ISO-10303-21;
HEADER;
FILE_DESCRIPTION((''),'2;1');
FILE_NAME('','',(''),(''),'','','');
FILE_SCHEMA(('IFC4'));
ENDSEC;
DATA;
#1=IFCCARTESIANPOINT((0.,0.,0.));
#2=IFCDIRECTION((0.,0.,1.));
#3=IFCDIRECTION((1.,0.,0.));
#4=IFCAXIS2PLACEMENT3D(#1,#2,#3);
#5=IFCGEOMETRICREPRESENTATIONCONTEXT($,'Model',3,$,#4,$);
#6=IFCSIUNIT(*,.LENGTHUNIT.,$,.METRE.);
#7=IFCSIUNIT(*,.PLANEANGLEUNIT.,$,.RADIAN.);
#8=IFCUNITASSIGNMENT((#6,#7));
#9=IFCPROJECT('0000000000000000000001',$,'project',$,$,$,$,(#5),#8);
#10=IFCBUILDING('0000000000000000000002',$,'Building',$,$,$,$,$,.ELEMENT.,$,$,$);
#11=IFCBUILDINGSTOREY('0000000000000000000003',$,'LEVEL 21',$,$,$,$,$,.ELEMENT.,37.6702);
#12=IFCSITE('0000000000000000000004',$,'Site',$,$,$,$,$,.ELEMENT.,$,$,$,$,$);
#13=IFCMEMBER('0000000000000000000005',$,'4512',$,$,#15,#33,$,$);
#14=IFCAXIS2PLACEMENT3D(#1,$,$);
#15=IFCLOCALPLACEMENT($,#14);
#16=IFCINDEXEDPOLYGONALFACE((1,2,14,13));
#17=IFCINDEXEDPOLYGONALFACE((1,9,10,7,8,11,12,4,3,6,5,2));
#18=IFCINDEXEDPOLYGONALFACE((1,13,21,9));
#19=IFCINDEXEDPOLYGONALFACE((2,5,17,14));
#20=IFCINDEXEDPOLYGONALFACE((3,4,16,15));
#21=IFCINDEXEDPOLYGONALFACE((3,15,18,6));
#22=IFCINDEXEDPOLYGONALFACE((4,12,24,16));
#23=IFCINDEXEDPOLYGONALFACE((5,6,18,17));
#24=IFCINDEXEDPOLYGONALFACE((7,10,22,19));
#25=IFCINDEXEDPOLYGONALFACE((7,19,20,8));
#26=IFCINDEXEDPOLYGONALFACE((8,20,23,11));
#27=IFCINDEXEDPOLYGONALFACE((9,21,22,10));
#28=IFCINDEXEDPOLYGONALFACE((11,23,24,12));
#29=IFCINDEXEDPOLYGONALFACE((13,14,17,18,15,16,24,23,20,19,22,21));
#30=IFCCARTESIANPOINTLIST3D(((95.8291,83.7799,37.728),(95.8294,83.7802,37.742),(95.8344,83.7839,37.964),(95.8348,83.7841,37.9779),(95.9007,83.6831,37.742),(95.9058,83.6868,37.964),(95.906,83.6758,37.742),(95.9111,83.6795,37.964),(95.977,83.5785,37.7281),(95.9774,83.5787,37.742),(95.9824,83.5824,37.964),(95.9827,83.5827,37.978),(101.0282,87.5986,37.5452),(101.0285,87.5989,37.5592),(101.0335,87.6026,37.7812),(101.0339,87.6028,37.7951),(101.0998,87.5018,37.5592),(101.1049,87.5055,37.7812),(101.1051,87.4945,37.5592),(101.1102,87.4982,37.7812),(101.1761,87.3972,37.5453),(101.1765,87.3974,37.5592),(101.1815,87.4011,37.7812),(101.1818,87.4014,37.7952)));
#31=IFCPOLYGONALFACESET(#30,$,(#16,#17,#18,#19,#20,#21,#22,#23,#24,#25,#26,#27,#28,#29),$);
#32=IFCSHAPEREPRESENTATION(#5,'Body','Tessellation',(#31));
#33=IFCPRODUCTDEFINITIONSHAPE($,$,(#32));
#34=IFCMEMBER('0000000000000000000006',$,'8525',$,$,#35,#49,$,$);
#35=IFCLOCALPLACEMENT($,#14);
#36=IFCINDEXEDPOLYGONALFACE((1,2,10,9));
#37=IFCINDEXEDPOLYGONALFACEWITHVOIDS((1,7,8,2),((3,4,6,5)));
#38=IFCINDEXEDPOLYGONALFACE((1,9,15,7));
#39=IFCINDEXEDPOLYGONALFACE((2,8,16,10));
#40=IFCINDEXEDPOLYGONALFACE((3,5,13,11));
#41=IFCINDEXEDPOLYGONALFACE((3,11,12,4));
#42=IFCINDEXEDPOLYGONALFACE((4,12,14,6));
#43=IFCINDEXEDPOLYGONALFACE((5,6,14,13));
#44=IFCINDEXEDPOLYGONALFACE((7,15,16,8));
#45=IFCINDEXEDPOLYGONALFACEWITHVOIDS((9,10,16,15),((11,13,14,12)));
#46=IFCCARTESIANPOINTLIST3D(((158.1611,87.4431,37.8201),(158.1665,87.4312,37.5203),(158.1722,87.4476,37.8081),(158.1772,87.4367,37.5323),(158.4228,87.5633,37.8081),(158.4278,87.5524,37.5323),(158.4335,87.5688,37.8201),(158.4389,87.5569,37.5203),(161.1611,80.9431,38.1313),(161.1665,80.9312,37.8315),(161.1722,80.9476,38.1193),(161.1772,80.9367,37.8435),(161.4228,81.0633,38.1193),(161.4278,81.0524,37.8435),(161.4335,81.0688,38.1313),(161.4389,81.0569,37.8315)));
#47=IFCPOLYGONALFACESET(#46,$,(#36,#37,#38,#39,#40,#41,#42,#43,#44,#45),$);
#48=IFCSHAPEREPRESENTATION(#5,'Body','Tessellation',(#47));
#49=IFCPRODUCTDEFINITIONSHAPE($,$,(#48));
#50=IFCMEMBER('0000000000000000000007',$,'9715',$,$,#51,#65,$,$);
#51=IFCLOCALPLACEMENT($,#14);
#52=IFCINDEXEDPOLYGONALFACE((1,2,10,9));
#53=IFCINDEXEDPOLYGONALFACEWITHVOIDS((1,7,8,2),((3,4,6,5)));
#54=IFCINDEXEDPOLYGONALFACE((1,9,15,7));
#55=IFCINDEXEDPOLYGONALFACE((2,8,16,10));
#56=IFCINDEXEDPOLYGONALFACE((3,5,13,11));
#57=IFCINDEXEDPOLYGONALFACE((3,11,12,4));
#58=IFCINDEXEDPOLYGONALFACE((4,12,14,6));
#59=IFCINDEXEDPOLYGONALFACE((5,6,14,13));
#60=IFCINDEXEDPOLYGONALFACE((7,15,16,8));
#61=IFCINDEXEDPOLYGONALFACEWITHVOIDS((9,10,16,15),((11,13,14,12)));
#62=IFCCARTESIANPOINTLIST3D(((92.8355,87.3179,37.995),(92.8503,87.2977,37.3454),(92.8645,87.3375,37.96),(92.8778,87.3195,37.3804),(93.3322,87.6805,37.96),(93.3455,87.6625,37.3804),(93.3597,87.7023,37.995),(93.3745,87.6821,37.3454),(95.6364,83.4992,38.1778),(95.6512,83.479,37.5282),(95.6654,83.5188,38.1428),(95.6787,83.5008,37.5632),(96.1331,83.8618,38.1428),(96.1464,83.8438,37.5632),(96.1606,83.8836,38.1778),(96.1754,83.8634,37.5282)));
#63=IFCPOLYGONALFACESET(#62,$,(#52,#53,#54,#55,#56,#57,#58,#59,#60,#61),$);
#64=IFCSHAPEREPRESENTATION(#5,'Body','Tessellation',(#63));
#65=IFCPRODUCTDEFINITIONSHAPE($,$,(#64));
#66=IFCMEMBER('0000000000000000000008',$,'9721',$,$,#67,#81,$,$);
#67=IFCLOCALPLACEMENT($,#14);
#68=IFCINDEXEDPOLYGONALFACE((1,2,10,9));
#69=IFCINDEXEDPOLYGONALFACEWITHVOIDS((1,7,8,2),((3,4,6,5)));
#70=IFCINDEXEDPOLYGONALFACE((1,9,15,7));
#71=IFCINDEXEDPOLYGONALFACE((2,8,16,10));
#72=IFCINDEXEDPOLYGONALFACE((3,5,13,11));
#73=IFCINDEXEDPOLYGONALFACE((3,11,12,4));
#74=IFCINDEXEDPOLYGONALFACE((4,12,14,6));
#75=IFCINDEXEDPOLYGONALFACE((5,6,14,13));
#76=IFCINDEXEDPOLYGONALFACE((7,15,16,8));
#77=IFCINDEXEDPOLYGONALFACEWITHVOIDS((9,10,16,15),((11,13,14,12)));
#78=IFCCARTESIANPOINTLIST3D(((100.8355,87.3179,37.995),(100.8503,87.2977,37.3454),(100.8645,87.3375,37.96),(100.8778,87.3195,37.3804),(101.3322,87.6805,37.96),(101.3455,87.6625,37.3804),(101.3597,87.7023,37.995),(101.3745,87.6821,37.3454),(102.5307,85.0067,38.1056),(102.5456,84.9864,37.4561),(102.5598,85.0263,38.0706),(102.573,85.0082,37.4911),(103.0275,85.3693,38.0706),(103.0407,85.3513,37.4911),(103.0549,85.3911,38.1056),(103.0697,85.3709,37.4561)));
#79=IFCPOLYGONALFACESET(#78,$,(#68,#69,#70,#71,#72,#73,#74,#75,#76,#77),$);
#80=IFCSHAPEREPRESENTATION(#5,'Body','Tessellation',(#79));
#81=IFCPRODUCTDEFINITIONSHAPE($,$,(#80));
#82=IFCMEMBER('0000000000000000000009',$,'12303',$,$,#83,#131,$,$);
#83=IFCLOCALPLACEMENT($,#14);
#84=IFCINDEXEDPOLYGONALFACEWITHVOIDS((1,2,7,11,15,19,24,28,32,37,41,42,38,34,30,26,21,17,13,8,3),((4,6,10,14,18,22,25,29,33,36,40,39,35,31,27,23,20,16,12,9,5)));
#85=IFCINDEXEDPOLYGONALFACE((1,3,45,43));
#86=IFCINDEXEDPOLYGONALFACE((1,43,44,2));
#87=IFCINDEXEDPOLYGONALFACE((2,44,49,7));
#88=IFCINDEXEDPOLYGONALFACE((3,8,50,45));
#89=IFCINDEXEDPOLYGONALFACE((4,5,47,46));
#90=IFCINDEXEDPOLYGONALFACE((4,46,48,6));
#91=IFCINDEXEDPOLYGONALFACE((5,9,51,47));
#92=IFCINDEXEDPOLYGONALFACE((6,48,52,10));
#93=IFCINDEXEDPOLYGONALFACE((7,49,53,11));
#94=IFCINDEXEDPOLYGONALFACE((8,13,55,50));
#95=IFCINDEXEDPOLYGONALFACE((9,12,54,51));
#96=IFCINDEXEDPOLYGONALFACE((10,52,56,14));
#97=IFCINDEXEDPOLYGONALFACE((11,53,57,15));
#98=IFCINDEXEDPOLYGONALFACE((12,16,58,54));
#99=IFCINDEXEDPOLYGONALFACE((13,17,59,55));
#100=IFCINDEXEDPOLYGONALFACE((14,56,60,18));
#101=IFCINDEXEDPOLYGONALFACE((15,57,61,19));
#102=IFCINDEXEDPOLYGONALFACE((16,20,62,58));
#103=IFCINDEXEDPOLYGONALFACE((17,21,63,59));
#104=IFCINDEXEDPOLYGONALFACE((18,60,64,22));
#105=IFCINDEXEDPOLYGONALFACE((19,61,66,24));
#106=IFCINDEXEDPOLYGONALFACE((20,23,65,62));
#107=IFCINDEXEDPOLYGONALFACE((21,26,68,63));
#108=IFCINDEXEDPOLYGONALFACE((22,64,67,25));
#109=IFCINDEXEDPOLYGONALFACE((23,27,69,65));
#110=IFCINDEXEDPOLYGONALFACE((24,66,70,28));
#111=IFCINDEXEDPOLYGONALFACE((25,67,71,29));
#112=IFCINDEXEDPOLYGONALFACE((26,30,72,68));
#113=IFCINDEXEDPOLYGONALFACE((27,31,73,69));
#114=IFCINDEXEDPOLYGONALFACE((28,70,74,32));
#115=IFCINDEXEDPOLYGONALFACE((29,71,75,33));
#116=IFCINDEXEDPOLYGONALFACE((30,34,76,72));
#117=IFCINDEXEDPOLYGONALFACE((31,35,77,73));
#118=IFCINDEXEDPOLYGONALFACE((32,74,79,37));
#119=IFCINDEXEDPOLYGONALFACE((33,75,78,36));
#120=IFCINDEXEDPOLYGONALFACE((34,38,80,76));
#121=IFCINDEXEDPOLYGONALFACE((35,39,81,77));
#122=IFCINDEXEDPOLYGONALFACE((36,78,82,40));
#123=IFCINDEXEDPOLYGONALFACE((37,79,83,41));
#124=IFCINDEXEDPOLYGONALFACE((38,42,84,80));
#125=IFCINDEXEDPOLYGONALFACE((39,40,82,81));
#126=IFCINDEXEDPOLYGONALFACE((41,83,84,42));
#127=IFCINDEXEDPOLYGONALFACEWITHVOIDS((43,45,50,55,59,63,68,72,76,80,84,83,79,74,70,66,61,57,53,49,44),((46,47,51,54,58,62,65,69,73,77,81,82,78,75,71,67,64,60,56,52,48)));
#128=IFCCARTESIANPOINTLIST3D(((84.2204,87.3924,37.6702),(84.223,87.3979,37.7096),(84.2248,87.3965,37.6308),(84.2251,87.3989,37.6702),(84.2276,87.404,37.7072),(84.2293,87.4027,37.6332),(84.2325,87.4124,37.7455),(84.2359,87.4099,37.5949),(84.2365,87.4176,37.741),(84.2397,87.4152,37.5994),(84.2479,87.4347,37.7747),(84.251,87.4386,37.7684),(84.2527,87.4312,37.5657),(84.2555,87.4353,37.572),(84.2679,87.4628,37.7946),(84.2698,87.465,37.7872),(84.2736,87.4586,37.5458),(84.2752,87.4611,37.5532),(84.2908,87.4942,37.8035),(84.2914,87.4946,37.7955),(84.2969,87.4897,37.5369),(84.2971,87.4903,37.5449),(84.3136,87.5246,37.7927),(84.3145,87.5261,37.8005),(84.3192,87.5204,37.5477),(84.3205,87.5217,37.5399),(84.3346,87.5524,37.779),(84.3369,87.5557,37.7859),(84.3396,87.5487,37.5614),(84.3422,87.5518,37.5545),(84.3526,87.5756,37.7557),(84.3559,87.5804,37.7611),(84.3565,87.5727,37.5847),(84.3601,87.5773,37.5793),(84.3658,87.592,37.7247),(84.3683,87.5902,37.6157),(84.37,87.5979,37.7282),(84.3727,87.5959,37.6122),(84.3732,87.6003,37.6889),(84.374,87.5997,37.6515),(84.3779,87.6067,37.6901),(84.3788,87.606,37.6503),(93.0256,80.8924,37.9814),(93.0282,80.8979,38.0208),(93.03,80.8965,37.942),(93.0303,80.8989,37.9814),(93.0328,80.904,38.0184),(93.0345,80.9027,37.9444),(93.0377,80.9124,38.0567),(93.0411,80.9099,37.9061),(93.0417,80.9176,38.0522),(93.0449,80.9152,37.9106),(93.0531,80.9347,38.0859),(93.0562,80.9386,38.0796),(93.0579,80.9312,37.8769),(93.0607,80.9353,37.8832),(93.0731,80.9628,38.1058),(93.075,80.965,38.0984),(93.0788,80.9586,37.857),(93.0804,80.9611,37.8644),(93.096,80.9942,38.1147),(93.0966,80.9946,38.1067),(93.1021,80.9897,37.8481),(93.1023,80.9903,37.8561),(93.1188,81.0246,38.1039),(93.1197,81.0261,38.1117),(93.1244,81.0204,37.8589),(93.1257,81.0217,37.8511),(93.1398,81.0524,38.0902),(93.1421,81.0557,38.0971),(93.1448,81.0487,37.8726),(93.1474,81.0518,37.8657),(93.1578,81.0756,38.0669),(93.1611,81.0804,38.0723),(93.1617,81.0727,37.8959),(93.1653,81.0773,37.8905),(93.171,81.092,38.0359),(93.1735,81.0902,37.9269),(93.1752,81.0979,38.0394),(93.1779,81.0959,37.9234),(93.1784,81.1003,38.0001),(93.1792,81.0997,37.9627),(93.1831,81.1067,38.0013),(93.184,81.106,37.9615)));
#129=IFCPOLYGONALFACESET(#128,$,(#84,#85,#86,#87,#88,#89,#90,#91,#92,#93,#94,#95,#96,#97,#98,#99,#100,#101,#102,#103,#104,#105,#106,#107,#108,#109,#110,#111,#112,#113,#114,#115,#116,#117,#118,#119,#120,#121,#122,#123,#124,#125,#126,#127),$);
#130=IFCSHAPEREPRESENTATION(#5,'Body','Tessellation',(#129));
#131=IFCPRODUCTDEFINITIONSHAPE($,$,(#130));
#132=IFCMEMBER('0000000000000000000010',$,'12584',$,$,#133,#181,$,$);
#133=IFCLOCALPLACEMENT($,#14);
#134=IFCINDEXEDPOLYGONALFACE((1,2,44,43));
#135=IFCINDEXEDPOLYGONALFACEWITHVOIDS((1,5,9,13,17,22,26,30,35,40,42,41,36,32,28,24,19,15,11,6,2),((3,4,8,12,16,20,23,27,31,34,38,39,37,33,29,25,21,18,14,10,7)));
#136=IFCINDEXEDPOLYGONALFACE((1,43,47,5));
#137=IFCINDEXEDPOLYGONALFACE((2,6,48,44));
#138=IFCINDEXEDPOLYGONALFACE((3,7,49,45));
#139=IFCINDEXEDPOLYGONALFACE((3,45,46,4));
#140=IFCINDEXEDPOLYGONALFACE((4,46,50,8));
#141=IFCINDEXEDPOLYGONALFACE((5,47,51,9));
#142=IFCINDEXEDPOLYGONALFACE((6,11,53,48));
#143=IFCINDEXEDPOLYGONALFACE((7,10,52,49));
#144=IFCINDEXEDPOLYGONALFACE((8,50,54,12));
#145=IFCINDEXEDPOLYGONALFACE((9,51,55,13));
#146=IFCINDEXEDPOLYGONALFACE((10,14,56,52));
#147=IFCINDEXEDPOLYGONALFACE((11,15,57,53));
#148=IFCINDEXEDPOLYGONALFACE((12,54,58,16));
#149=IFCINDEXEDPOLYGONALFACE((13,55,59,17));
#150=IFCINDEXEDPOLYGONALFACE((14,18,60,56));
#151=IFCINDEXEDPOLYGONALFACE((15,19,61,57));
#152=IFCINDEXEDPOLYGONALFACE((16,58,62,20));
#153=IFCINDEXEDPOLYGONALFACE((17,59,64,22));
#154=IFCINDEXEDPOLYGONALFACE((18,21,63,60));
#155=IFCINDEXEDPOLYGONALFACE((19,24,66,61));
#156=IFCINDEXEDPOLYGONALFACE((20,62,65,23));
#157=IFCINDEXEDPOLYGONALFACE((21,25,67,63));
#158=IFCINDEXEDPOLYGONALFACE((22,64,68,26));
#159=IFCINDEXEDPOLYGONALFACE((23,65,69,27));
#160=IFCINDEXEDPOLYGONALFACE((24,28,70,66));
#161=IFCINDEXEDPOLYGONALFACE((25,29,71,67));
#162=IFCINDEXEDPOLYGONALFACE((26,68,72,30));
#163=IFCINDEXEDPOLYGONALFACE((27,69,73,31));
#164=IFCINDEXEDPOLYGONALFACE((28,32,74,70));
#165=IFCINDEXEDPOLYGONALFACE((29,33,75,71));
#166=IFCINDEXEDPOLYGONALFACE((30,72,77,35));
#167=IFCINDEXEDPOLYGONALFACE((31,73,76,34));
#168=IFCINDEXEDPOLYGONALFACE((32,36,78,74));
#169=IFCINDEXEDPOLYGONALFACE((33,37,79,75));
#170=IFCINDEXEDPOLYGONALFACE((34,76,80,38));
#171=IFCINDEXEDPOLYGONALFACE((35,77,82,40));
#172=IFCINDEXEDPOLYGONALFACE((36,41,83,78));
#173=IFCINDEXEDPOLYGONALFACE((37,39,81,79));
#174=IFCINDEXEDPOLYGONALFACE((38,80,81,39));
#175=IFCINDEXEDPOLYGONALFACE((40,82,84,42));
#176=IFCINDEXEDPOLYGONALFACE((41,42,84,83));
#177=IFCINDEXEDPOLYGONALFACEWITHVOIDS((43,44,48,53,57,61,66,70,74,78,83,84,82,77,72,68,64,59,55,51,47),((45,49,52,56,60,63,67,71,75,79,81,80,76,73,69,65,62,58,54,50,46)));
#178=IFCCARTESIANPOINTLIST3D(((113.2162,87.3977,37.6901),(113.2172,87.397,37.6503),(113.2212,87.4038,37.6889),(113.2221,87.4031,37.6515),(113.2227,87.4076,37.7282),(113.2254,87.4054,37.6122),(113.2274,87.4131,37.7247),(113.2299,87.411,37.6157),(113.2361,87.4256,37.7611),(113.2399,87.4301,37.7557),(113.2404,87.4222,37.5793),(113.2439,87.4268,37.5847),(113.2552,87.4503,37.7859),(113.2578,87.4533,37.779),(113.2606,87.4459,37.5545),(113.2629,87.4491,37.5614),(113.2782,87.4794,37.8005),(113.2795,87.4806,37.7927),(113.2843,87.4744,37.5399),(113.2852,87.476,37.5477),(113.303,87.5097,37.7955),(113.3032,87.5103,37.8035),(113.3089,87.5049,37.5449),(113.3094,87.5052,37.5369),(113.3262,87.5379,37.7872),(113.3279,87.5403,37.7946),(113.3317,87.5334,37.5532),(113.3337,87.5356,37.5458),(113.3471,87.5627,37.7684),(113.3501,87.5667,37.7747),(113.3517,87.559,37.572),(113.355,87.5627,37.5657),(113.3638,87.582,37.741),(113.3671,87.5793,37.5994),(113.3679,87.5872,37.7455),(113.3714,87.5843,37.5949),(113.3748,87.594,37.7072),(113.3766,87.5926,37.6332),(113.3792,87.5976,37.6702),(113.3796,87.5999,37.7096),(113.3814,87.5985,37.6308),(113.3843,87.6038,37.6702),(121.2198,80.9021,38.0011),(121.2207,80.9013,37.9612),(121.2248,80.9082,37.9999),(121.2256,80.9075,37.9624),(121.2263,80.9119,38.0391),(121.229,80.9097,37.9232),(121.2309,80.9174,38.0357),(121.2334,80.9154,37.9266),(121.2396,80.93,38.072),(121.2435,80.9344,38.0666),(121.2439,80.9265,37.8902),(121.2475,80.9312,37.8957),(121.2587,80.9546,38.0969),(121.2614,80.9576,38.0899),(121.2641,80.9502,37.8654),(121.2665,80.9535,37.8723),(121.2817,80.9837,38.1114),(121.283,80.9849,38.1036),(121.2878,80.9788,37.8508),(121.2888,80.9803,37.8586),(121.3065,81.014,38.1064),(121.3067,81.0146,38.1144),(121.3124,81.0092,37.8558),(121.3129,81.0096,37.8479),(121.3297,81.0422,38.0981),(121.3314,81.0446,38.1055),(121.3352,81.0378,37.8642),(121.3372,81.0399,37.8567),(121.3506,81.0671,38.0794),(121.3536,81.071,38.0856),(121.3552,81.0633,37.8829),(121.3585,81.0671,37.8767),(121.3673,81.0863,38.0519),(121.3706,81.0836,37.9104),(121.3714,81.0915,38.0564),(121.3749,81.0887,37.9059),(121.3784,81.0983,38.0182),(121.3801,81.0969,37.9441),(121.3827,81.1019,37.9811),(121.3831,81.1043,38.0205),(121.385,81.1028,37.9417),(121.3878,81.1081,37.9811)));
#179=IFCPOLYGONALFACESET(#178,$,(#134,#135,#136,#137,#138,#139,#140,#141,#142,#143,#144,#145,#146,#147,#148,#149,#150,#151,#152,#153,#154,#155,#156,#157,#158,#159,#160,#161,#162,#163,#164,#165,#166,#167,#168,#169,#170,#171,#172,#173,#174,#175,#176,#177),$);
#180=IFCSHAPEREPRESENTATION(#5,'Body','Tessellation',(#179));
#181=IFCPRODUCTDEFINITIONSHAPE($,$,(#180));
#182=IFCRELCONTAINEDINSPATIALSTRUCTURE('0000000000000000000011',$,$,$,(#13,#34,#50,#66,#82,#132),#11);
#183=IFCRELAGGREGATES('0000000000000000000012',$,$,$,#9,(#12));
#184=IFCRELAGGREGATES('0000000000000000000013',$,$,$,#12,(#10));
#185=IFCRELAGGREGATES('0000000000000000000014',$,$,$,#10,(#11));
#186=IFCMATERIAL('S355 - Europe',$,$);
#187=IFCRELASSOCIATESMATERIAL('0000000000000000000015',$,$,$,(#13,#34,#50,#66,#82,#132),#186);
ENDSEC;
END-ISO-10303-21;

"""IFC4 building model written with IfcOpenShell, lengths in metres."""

from ifc_helpers import new_model, si_unit, frame, origin_with_axes, origin_2d_with_axis, place, context, project, spatial, hollow_rectangle, hollow_circle, i_section, extrude, material, material_profile, profile_set, profile_usage, element, save


model = new_model("IFC4")

# Units and contexts
model_context = context("Model", 3, world=origin_with_axes())
ifc_project = project(units=[si_unit("LENGTHUNIT", "METRE"), si_unit("PLANEANGLEUNIT", "RADIAN")], contexts=[model_context])

# Site, building, storey
site = spatial("IfcSite", under=ifc_project, Name="Site", CompositionType="ELEMENT")
building = spatial("IfcBuilding", under=site, Name="Building", CompositionType="ELEMENT")
storey = spatial("IfcBuildingStorey", under=building, Name="LEVEL 21", CompositionType="ELEMENT", Elevation=37.6702)

# Shared definitions
ifc_material = material(Name="S355 - Europe")

# Members
ifc_material_profile_1 = material_profile(ifc_material, i_section(OverallWidth=0.25, OverallDepth=0.25, WebThickness=0.009, FlangeThickness=0.014, at=origin_2d_with_axis()))
ifc_profile_set_1 = profile_set([ifc_material_profile_1])
ifc_profile_usage_1 = profile_usage(ifc_profile_set_1, cardinal=10)
member_1_placement = place(None, frame((101.105, 87.5, 37.6702), z_axis=(-0.805636, -0.591733, 0.028326), x_axis=(0.592045, -0.805905, 0.0)))
element("IfcMember", 1, at=member_1_placement, inside=storey, material=ifc_profile_usage_1, Name="4512", context=model_context, shape_type="SweptSolid", body=[
    extrude(i_section(OverallWidth=0.25, OverallDepth=0.25, WebThickness=0.009, FlangeThickness=0.014, at=origin_2d_with_axis()), origin_with_axes(), (0.0, 0.0, 1.0), 6.4534),
])
ifc_material_profile_2 = material_profile(ifc_material, hollow_rectangle(XDim=0.3, YDim=0.3, WallThickness=0.012, at=origin_2d_with_axis()))
ifc_profile_set_2 = profile_set([ifc_material_profile_2])
ifc_profile_usage_2 = profile_usage(ifc_profile_set_2, cardinal=10)
member_2_placement = place(None, frame((158.3, 87.5, 37.6702), z_axis=(0.418663, -0.907103, 0.043429), x_axis=(0.907959, 0.419058, 0.0)))
element("IfcMember", 2, at=member_2_placement, inside=storey, material=ifc_profile_usage_2, Name="8525", context=model_context, shape_type="SweptSolid", body=[
    extrude(hollow_rectangle(XDim=0.3, YDim=0.3, WallThickness=0.012, at=origin_2d_with_axis()), origin_with_axes(), (0.0, 0.0, 1.0), 7.1657),
])
ifc_material_profile_3 = material_profile(ifc_material, hollow_rectangle(XDim=0.65, YDim=0.65, WallThickness=0.035, at=origin_2d_with_axis()))
ifc_profile_set_3 = profile_set([ifc_material_profile_3])
ifc_profile_usage_3 = profile_usage(ifc_profile_set_3, cardinal=10)
member_3_placement = place(None, frame((93.105, 87.5, 37.6702), z_axis=(0.590995, -0.805753, 0.038571), x_axis=(0.806353, 0.591435, 0.0)))
element("IfcMember", 3, at=member_3_placement, inside=storey, material=ifc_profile_usage_3, Name="9715", context=model_context, shape_type="SweptSolid", body=[
    extrude(hollow_rectangle(XDim=0.65, YDim=0.65, WallThickness=0.035, at=origin_2d_with_axis()), origin_with_axes(), (0.0, 0.0, 1.0), 4.7393),
])
ifc_material_profile_4 = material_profile(ifc_material, hollow_rectangle(XDim=0.65, YDim=0.65, WallThickness=0.035, at=origin_2d_with_axis()))
ifc_profile_set_4 = profile_set([ifc_material_profile_4])
ifc_profile_usage_4 = profile_usage(ifc_profile_set_4, cardinal=10)
member_4_placement = place(None, frame((101.105, 87.5, 37.6702), z_axis=(0.590995, -0.805753, 0.038571), x_axis=(0.806353, 0.591435, 0.0)))
element("IfcMember", 4, at=member_4_placement, inside=storey, material=ifc_profile_usage_4, Name="9721", context=model_context, shape_type="SweptSolid", body=[
    extrude(hollow_rectangle(XDim=0.65, YDim=0.65, WallThickness=0.035, at=origin_2d_with_axis()), origin_with_axes(), (0.0, 0.0, 1.0), 2.8684),
])
ifc_material_profile_5 = material_profile(ifc_material, hollow_circle(Radius=0.1337, WallThickness=0.008, at=origin_2d_with_axis()))
ifc_profile_set_5 = profile_set([ifc_material_profile_5])
ifc_profile_usage_5 = profile_usage(ifc_profile_set_5, cardinal=10)
member_5_placement = place(None, frame((93.105, 81.0, 37.9814), z_axis=(-0.804209, 0.593667, -0.028423), x_axis=(-0.593199, -0.805056, 0.0)))
element("IfcMember", 5, at=member_5_placement, inside=storey, material=ifc_profile_usage_5, Name="12303", context=model_context, shape_type="SweptSolid", body=[
    extrude(hollow_circle(Radius=0.1337, WallThickness=0.008, at=origin_2d_with_axis()), origin_with_axes(), (0.0, 0.0, 1.0), 10.9489),
])
ifc_material_profile_6 = material_profile(ifc_material, hollow_circle(Radius=0.1337, WallThickness=0.008, at=origin_2d_with_axis()))
ifc_profile_set_6 = profile_set([ifc_material_profile_6])
ifc_profile_usage_6 = profile_usage(ifc_profile_set_6, cardinal=10)
member_6_placement = place(None, frame((113.3, 87.5, 37.6702), z_axis=(0.776103, -0.629885, 0.030152), x_axis=(0.630172, 0.776456, 0.0)))
element("IfcMember", 6, at=member_6_placement, inside=storey, material=ifc_profile_usage_6, Name="12584", context=model_context, shape_type="SweptSolid", body=[
    extrude(hollow_circle(Radius=0.1337, WallThickness=0.008, at=origin_2d_with_axis()), origin_with_axes(), (0.0, 0.0, 1.0), 10.3125),
])

save(model, "model.ifc")
